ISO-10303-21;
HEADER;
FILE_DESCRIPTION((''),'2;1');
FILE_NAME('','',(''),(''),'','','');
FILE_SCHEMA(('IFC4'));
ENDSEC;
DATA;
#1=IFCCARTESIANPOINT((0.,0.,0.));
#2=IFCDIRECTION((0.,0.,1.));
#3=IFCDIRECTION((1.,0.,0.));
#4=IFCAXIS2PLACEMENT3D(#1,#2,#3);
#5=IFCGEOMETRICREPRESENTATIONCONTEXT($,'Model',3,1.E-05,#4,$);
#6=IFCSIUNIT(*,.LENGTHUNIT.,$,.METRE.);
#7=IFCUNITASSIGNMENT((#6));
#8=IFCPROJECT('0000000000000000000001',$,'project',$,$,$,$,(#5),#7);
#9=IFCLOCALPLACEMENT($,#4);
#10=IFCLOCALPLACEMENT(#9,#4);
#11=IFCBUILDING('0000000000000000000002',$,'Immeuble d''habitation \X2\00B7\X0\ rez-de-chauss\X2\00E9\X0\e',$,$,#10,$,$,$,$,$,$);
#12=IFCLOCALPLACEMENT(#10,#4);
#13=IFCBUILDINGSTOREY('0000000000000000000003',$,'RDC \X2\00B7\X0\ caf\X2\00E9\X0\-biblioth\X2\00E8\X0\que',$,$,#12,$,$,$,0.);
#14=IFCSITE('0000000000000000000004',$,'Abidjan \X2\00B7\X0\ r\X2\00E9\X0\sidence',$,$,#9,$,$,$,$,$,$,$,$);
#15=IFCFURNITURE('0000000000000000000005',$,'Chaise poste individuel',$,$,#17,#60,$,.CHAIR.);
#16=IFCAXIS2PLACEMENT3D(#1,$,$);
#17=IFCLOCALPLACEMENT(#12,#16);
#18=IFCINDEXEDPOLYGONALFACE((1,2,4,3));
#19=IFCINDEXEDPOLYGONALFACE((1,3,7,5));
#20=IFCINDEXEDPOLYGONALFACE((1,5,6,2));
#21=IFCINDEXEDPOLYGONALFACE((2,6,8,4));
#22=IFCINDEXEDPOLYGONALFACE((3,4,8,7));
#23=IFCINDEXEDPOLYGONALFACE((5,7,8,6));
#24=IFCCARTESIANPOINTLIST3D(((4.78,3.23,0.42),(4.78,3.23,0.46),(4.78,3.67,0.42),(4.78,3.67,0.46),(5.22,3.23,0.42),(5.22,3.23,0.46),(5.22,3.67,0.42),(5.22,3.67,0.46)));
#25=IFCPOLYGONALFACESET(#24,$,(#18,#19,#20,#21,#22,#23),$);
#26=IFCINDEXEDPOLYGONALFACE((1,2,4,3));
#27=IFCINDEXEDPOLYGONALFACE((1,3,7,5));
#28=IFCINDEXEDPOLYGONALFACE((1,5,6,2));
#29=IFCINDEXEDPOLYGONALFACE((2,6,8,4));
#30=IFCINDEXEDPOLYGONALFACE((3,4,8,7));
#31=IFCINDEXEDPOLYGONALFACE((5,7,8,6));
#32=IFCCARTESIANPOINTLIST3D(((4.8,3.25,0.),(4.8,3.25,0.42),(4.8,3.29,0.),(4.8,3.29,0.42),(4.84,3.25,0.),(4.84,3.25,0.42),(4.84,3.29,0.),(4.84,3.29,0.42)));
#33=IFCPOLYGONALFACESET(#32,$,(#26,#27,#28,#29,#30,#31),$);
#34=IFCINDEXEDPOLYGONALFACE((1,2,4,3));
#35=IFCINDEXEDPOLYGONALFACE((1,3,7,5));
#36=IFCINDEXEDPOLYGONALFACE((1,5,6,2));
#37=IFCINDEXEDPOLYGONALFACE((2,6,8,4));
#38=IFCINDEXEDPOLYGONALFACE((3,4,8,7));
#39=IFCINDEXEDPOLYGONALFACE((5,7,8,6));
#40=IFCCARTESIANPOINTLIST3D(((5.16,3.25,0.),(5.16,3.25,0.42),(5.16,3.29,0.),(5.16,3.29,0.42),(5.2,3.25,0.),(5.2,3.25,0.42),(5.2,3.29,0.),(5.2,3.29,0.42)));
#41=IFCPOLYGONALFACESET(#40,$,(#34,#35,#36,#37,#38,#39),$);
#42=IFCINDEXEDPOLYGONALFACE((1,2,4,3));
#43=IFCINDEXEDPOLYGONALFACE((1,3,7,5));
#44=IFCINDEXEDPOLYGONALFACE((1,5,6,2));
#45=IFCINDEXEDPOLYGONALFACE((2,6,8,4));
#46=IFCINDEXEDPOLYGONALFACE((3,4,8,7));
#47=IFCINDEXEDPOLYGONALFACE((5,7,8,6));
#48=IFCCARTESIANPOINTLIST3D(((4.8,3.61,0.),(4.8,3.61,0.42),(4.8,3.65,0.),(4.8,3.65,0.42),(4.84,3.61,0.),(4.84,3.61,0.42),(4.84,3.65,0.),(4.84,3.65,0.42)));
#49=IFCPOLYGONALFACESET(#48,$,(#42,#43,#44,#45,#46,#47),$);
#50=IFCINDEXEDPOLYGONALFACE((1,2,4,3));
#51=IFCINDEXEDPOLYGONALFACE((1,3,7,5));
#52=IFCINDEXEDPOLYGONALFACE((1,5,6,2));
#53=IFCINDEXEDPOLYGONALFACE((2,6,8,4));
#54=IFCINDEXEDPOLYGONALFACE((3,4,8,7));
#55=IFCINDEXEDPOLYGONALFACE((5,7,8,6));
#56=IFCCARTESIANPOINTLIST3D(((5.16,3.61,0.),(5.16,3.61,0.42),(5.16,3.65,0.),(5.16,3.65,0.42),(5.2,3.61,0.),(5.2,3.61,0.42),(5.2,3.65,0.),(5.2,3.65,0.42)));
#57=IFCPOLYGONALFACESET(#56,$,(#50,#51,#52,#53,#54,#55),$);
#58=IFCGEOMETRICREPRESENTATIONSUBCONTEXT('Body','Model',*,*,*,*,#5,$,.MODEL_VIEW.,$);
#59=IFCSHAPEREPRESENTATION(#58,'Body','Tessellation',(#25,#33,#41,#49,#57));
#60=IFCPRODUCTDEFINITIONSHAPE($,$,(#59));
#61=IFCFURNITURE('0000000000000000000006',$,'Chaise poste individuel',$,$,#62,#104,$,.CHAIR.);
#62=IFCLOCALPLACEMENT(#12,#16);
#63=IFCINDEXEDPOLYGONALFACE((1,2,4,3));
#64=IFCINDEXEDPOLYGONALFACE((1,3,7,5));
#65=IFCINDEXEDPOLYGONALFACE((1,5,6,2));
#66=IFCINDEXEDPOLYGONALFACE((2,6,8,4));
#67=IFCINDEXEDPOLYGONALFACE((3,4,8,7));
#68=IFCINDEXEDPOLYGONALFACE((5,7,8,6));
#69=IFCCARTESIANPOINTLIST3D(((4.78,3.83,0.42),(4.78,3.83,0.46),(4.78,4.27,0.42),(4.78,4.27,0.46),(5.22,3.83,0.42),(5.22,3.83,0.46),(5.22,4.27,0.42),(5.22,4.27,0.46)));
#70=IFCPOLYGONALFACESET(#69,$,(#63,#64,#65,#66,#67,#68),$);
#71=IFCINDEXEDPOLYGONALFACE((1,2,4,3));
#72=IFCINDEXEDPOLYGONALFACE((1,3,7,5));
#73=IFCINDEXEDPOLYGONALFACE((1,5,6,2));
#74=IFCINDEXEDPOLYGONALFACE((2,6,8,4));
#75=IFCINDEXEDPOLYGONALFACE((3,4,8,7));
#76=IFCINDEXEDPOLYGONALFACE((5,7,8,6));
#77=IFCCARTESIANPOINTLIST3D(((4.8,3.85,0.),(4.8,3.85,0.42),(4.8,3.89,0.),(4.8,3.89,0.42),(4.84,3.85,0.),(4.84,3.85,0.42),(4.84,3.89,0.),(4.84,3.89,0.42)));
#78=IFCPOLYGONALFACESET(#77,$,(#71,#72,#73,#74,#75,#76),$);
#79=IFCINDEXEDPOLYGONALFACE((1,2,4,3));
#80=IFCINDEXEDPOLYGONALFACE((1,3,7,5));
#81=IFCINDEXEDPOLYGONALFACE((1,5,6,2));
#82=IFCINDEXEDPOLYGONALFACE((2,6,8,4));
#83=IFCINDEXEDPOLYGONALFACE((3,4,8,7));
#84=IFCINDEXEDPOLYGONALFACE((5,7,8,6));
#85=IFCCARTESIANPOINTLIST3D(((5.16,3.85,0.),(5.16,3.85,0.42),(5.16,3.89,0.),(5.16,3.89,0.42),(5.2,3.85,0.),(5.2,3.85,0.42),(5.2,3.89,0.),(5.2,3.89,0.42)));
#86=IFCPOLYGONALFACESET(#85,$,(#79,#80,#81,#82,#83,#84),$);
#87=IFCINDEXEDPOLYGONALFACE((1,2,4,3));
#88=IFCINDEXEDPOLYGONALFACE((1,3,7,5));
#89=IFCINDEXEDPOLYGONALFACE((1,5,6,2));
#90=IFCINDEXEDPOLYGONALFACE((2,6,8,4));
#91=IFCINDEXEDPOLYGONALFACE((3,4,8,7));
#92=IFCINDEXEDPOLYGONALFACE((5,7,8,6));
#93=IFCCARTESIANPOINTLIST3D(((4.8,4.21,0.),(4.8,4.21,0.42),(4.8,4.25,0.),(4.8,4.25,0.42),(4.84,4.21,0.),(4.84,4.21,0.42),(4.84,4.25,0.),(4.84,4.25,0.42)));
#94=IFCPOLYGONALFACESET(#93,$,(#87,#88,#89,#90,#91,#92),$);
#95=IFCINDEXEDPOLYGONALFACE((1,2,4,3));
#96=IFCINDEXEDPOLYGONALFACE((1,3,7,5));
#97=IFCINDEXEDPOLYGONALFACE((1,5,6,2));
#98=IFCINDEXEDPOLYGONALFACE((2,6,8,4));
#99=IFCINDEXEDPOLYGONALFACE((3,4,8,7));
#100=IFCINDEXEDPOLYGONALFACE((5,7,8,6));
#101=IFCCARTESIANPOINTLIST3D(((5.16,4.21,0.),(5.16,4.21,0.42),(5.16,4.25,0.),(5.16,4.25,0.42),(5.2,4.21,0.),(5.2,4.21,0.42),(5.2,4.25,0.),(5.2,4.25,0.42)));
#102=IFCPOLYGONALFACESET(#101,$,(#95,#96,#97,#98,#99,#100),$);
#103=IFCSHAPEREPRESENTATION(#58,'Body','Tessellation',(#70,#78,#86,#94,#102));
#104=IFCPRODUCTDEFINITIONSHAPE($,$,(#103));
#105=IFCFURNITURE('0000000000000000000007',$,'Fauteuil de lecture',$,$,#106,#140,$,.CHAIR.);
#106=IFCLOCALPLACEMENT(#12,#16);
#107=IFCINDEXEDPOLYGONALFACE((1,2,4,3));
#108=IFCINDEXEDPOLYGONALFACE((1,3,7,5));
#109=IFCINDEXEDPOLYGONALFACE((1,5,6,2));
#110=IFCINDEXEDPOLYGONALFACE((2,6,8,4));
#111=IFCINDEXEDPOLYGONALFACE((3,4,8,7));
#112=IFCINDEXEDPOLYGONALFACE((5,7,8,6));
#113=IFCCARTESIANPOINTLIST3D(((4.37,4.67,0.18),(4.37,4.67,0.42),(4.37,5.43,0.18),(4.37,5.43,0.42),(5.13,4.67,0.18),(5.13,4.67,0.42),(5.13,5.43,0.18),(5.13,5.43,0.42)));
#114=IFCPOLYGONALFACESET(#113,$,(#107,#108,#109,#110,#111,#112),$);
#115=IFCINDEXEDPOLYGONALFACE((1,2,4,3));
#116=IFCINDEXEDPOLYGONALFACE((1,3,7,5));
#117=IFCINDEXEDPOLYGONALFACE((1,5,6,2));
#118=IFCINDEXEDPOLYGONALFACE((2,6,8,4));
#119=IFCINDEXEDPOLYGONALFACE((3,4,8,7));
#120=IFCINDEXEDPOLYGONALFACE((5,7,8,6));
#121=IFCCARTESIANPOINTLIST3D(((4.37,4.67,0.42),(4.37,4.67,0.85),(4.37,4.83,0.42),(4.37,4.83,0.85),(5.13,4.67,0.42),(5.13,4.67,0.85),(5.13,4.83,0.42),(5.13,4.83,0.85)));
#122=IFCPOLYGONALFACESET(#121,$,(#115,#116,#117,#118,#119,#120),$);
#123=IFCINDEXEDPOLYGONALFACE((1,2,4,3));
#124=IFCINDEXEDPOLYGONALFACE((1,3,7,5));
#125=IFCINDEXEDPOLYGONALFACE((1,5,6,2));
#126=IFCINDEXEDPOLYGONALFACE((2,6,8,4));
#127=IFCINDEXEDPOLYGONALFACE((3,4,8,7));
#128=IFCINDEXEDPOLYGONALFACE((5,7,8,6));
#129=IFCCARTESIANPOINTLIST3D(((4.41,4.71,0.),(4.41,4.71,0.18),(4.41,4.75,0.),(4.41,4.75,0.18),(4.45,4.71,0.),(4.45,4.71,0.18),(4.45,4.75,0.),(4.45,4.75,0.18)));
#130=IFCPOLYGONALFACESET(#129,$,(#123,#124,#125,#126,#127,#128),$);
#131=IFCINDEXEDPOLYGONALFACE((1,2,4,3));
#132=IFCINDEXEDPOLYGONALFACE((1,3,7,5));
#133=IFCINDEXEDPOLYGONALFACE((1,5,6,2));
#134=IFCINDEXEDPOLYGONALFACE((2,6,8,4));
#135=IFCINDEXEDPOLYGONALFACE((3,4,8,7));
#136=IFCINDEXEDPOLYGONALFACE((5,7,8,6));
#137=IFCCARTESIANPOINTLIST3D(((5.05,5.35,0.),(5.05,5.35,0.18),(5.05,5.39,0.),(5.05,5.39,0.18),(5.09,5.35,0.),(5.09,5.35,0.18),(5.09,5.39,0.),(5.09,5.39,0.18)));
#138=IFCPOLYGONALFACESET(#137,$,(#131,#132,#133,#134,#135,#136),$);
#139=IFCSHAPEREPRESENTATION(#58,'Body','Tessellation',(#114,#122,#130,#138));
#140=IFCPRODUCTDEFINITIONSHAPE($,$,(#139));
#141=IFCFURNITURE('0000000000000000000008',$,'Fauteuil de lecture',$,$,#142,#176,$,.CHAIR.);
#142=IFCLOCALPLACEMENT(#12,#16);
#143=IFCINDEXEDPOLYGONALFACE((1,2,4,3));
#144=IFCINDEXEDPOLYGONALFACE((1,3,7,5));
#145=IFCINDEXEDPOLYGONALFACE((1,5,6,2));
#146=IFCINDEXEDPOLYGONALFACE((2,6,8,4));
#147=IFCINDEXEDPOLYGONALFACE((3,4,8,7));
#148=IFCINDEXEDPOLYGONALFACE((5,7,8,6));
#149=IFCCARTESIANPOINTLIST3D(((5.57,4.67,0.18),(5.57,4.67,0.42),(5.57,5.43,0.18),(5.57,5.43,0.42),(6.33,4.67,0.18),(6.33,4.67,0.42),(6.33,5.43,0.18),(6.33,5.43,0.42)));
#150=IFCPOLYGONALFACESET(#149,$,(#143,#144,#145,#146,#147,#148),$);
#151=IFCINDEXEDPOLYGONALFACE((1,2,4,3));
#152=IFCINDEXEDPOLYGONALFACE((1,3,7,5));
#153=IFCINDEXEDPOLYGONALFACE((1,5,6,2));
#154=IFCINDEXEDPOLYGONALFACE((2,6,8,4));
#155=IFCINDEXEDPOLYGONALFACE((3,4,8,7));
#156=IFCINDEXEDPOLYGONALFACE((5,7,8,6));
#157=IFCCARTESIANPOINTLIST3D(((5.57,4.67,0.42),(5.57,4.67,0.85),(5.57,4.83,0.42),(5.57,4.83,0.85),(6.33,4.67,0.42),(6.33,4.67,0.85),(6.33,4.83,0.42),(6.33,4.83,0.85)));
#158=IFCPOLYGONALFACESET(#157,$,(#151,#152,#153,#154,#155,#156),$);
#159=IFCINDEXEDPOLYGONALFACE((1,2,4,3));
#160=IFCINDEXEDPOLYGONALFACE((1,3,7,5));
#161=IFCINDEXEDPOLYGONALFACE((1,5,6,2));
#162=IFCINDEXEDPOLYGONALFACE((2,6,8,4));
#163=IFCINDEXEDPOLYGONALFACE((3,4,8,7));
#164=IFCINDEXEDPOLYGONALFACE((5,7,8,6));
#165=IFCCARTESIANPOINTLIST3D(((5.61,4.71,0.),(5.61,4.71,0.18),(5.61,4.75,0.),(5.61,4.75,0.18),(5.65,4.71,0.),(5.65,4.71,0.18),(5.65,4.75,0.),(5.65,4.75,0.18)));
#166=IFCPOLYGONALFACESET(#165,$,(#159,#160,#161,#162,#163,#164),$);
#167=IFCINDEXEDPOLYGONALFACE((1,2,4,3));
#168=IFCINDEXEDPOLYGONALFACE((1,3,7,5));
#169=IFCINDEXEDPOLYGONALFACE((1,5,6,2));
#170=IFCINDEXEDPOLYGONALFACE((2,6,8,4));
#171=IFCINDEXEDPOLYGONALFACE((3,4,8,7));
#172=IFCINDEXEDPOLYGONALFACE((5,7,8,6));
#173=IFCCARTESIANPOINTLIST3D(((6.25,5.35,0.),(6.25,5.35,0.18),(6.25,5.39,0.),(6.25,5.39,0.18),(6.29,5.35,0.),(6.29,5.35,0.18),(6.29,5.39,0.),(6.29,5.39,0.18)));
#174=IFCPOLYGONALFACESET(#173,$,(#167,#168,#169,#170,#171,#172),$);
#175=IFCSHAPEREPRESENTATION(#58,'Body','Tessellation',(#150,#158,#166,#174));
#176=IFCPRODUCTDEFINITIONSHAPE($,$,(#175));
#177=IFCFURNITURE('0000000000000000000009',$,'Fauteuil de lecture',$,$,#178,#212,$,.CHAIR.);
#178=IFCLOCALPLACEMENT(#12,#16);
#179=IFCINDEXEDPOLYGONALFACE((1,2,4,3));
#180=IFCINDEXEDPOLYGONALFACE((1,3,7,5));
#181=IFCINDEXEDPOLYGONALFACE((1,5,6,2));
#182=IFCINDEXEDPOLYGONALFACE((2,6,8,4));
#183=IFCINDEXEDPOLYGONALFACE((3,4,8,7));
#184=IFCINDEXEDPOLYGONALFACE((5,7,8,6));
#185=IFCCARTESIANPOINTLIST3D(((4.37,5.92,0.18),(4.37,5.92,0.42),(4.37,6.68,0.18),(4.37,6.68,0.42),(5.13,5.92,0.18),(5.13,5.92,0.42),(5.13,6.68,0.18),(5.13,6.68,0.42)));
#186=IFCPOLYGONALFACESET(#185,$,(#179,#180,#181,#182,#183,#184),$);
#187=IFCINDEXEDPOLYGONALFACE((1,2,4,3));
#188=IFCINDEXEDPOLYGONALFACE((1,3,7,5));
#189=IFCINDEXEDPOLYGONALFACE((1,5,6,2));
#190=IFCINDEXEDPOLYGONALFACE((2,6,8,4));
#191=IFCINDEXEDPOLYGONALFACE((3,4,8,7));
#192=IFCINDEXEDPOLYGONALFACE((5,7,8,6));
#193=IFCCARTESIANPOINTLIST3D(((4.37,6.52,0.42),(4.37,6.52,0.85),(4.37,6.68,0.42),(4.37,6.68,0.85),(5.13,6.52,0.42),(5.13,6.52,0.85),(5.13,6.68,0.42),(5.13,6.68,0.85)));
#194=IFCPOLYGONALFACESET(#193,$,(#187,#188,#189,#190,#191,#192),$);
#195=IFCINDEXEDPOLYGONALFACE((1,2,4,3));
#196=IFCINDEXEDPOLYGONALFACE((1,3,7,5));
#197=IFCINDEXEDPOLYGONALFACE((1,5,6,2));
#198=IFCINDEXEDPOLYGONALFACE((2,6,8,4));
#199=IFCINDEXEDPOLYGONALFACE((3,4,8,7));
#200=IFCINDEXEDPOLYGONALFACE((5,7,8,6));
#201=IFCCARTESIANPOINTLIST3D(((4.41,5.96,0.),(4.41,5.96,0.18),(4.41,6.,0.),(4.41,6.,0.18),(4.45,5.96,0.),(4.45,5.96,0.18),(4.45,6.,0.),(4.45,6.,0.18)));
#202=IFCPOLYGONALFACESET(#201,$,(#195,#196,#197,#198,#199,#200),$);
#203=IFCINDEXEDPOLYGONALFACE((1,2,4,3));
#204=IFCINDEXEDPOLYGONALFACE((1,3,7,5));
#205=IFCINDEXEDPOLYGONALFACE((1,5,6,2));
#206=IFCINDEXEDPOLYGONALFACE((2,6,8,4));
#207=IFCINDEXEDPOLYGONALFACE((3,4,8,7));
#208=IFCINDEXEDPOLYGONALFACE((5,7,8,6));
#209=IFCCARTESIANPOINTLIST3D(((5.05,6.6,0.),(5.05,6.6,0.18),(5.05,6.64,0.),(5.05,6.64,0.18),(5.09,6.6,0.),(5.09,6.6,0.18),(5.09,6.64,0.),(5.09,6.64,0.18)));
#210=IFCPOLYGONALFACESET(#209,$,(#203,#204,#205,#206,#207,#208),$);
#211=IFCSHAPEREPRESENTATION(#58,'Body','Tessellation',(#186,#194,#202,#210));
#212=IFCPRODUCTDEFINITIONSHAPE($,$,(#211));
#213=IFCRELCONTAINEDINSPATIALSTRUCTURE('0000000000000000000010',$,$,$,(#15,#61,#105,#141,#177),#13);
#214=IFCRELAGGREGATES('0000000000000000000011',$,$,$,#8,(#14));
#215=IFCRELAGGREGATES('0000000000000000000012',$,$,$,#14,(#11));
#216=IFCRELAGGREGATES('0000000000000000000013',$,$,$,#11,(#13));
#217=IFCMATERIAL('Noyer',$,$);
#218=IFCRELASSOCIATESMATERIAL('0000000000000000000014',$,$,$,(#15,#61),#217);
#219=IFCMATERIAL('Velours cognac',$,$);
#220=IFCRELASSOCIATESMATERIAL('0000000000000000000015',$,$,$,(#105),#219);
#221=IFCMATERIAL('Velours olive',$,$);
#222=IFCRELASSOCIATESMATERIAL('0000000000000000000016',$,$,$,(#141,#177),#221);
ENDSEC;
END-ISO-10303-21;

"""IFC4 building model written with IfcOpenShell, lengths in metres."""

from ifc_helpers import new_model, si_unit, frame, frame_2d, origin, origin_with_axes, place, context, subcontext, project, spatial, rectangle, extrude, material, element, save


model = new_model("IFC4")

# Units and contexts
model_context = context("Model", 3, precision=1e-05, world=origin_with_axes())
body_context = subcontext(model_context, "Body", "Model", "MODEL_VIEW")
ifc_project = project(units=[si_unit("LENGTHUNIT", "METRE")], contexts=[model_context])

# Site, building, storey
site_placement = place(None, origin_with_axes())
site = spatial("IfcSite", under=ifc_project, at=site_placement, Name="Abidjan · résidence")
building_placement = place(site_placement, origin_with_axes())
building = spatial("IfcBuilding", under=site, at=building_placement, Name="Immeuble d'habitation · rez-de-chaussée")
storey_placement = place(building_placement, origin_with_axes())
storey = spatial("IfcBuildingStorey", under=building, at=storey_placement, Name="RDC · café-bibliothèque", Elevation=0.0)

# Furniture
ifc_material_1 = material(Name="Velours cognac")
ifc_material_2 = material(Name="Noyer")
furniture_1_placement = place(storey_placement, origin_with_axes())
element("IfcFurniture", 1, at=furniture_1_placement, inside=storey, material=ifc_material_2, Name="Chaise poste individuel", PredefinedType="CHAIR", context=body_context, shape_type="SweptSolid", body=[
    extrude(rectangle(XDim=0.44, YDim=0.44, at=frame_2d((5.0, 3.45))), frame((0.0, 0.0, 0.42)), (0.0, 0.0, 1.0), 0.04),
    extrude(rectangle(XDim=0.04, YDim=0.04, at=frame_2d((4.82, 3.27))), origin(), (0.0, 0.0, 1.0), 0.42),
    extrude(rectangle(XDim=0.04, YDim=0.04, at=frame_2d((5.18, 3.27))), origin(), (0.0, 0.0, 1.0), 0.42),
    extrude(rectangle(XDim=0.04, YDim=0.04, at=frame_2d((4.82, 3.63))), origin(), (0.0, 0.0, 1.0), 0.42),
    extrude(rectangle(XDim=0.04, YDim=0.04, at=frame_2d((5.18, 3.63))), origin(), (0.0, 0.0, 1.0), 0.42),
])
furniture_2_placement = place(storey_placement, origin_with_axes())
element("IfcFurniture", 2, at=furniture_2_placement, inside=storey, material=ifc_material_2, Name="Chaise poste individuel", PredefinedType="CHAIR", context=body_context, shape_type="SweptSolid", body=[
    extrude(rectangle(XDim=0.44, YDim=0.44, at=frame_2d((5.0, 4.05))), frame((0.0, 0.0, 0.42)), (0.0, 0.0, 1.0), 0.04),
    extrude(rectangle(XDim=0.04, YDim=0.04, at=frame_2d((4.82, 3.87))), origin(), (0.0, 0.0, 1.0), 0.42),
    extrude(rectangle(XDim=0.04, YDim=0.04, at=frame_2d((5.18, 3.87))), origin(), (0.0, 0.0, 1.0), 0.42),
    extrude(rectangle(XDim=0.04, YDim=0.04, at=frame_2d((4.82, 4.23))), origin(), (0.0, 0.0, 1.0), 0.42),
    extrude(rectangle(XDim=0.04, YDim=0.04, at=frame_2d((5.18, 4.23))), origin(), (0.0, 0.0, 1.0), 0.42),
])
furniture_3_placement = place(storey_placement, origin_with_axes())
element("IfcFurniture", 3, at=furniture_3_placement, inside=storey, material=ifc_material_1, Name="Fauteuil de lecture", PredefinedType="CHAIR", context=body_context, shape_type="SweptSolid", body=[
    extrude(rectangle(XDim=0.76, YDim=0.76, at=frame_2d((4.75, 5.05))), frame((0.0, 0.0, 0.18)), (0.0, 0.0, 1.0), 0.24),
    extrude(rectangle(XDim=0.76, YDim=0.16, at=frame_2d((4.75, 4.75))), frame((0.0, 0.0, 0.42)), (0.0, 0.0, 1.0), 0.43),
    extrude(rectangle(XDim=0.04, YDim=0.04, at=frame_2d((4.43, 4.73))), origin(), (0.0, 0.0, 1.0), 0.18),
    extrude(rectangle(XDim=0.04, YDim=0.04, at=frame_2d((5.07, 5.37))), origin(), (0.0, 0.0, 1.0), 0.18),
])
ifc_material_3 = material(Name="Velours olive")
furniture_4_placement = place(storey_placement, origin_with_axes())
element("IfcFurniture", 4, at=furniture_4_placement, inside=storey, material=ifc_material_3, Name="Fauteuil de lecture", PredefinedType="CHAIR", context=body_context, shape_type="SweptSolid", body=[
    extrude(rectangle(XDim=0.76, YDim=0.76, at=frame_2d((5.95, 5.05))), frame((0.0, 0.0, 0.18)), (0.0, 0.0, 1.0), 0.24),
    extrude(rectangle(XDim=0.76, YDim=0.16, at=frame_2d((5.95, 4.75))), frame((0.0, 0.0, 0.42)), (0.0, 0.0, 1.0), 0.43),
    extrude(rectangle(XDim=0.04, YDim=0.04, at=frame_2d((5.63, 4.73))), origin(), (0.0, 0.0, 1.0), 0.18),
    extrude(rectangle(XDim=0.04, YDim=0.04, at=frame_2d((6.27, 5.37))), origin(), (0.0, 0.0, 1.0), 0.18),
])
furniture_5_placement = place(storey_placement, origin_with_axes())
element("IfcFurniture", 5, at=furniture_5_placement, inside=storey, material=ifc_material_3, Name="Fauteuil de lecture", PredefinedType="CHAIR", context=body_context, shape_type="SweptSolid", body=[
    extrude(rectangle(XDim=0.76, YDim=0.76, at=frame_2d((4.75, 6.3))), frame((0.0, 0.0, 0.18)), (0.0, 0.0, 1.0), 0.24),
    extrude(rectangle(XDim=0.76, YDim=0.16, at=frame_2d((4.75, 6.6))), frame((0.0, 0.0, 0.42)), (0.0, 0.0, 1.0), 0.43),
    extrude(rectangle(XDim=0.04, YDim=0.04, at=frame_2d((4.43, 5.98))), origin(), (0.0, 0.0, 1.0), 0.18),
    extrude(rectangle(XDim=0.04, YDim=0.04, at=frame_2d((5.07, 6.62))), origin(), (0.0, 0.0, 1.0), 0.18),
])

save(model, "model.ifc")
